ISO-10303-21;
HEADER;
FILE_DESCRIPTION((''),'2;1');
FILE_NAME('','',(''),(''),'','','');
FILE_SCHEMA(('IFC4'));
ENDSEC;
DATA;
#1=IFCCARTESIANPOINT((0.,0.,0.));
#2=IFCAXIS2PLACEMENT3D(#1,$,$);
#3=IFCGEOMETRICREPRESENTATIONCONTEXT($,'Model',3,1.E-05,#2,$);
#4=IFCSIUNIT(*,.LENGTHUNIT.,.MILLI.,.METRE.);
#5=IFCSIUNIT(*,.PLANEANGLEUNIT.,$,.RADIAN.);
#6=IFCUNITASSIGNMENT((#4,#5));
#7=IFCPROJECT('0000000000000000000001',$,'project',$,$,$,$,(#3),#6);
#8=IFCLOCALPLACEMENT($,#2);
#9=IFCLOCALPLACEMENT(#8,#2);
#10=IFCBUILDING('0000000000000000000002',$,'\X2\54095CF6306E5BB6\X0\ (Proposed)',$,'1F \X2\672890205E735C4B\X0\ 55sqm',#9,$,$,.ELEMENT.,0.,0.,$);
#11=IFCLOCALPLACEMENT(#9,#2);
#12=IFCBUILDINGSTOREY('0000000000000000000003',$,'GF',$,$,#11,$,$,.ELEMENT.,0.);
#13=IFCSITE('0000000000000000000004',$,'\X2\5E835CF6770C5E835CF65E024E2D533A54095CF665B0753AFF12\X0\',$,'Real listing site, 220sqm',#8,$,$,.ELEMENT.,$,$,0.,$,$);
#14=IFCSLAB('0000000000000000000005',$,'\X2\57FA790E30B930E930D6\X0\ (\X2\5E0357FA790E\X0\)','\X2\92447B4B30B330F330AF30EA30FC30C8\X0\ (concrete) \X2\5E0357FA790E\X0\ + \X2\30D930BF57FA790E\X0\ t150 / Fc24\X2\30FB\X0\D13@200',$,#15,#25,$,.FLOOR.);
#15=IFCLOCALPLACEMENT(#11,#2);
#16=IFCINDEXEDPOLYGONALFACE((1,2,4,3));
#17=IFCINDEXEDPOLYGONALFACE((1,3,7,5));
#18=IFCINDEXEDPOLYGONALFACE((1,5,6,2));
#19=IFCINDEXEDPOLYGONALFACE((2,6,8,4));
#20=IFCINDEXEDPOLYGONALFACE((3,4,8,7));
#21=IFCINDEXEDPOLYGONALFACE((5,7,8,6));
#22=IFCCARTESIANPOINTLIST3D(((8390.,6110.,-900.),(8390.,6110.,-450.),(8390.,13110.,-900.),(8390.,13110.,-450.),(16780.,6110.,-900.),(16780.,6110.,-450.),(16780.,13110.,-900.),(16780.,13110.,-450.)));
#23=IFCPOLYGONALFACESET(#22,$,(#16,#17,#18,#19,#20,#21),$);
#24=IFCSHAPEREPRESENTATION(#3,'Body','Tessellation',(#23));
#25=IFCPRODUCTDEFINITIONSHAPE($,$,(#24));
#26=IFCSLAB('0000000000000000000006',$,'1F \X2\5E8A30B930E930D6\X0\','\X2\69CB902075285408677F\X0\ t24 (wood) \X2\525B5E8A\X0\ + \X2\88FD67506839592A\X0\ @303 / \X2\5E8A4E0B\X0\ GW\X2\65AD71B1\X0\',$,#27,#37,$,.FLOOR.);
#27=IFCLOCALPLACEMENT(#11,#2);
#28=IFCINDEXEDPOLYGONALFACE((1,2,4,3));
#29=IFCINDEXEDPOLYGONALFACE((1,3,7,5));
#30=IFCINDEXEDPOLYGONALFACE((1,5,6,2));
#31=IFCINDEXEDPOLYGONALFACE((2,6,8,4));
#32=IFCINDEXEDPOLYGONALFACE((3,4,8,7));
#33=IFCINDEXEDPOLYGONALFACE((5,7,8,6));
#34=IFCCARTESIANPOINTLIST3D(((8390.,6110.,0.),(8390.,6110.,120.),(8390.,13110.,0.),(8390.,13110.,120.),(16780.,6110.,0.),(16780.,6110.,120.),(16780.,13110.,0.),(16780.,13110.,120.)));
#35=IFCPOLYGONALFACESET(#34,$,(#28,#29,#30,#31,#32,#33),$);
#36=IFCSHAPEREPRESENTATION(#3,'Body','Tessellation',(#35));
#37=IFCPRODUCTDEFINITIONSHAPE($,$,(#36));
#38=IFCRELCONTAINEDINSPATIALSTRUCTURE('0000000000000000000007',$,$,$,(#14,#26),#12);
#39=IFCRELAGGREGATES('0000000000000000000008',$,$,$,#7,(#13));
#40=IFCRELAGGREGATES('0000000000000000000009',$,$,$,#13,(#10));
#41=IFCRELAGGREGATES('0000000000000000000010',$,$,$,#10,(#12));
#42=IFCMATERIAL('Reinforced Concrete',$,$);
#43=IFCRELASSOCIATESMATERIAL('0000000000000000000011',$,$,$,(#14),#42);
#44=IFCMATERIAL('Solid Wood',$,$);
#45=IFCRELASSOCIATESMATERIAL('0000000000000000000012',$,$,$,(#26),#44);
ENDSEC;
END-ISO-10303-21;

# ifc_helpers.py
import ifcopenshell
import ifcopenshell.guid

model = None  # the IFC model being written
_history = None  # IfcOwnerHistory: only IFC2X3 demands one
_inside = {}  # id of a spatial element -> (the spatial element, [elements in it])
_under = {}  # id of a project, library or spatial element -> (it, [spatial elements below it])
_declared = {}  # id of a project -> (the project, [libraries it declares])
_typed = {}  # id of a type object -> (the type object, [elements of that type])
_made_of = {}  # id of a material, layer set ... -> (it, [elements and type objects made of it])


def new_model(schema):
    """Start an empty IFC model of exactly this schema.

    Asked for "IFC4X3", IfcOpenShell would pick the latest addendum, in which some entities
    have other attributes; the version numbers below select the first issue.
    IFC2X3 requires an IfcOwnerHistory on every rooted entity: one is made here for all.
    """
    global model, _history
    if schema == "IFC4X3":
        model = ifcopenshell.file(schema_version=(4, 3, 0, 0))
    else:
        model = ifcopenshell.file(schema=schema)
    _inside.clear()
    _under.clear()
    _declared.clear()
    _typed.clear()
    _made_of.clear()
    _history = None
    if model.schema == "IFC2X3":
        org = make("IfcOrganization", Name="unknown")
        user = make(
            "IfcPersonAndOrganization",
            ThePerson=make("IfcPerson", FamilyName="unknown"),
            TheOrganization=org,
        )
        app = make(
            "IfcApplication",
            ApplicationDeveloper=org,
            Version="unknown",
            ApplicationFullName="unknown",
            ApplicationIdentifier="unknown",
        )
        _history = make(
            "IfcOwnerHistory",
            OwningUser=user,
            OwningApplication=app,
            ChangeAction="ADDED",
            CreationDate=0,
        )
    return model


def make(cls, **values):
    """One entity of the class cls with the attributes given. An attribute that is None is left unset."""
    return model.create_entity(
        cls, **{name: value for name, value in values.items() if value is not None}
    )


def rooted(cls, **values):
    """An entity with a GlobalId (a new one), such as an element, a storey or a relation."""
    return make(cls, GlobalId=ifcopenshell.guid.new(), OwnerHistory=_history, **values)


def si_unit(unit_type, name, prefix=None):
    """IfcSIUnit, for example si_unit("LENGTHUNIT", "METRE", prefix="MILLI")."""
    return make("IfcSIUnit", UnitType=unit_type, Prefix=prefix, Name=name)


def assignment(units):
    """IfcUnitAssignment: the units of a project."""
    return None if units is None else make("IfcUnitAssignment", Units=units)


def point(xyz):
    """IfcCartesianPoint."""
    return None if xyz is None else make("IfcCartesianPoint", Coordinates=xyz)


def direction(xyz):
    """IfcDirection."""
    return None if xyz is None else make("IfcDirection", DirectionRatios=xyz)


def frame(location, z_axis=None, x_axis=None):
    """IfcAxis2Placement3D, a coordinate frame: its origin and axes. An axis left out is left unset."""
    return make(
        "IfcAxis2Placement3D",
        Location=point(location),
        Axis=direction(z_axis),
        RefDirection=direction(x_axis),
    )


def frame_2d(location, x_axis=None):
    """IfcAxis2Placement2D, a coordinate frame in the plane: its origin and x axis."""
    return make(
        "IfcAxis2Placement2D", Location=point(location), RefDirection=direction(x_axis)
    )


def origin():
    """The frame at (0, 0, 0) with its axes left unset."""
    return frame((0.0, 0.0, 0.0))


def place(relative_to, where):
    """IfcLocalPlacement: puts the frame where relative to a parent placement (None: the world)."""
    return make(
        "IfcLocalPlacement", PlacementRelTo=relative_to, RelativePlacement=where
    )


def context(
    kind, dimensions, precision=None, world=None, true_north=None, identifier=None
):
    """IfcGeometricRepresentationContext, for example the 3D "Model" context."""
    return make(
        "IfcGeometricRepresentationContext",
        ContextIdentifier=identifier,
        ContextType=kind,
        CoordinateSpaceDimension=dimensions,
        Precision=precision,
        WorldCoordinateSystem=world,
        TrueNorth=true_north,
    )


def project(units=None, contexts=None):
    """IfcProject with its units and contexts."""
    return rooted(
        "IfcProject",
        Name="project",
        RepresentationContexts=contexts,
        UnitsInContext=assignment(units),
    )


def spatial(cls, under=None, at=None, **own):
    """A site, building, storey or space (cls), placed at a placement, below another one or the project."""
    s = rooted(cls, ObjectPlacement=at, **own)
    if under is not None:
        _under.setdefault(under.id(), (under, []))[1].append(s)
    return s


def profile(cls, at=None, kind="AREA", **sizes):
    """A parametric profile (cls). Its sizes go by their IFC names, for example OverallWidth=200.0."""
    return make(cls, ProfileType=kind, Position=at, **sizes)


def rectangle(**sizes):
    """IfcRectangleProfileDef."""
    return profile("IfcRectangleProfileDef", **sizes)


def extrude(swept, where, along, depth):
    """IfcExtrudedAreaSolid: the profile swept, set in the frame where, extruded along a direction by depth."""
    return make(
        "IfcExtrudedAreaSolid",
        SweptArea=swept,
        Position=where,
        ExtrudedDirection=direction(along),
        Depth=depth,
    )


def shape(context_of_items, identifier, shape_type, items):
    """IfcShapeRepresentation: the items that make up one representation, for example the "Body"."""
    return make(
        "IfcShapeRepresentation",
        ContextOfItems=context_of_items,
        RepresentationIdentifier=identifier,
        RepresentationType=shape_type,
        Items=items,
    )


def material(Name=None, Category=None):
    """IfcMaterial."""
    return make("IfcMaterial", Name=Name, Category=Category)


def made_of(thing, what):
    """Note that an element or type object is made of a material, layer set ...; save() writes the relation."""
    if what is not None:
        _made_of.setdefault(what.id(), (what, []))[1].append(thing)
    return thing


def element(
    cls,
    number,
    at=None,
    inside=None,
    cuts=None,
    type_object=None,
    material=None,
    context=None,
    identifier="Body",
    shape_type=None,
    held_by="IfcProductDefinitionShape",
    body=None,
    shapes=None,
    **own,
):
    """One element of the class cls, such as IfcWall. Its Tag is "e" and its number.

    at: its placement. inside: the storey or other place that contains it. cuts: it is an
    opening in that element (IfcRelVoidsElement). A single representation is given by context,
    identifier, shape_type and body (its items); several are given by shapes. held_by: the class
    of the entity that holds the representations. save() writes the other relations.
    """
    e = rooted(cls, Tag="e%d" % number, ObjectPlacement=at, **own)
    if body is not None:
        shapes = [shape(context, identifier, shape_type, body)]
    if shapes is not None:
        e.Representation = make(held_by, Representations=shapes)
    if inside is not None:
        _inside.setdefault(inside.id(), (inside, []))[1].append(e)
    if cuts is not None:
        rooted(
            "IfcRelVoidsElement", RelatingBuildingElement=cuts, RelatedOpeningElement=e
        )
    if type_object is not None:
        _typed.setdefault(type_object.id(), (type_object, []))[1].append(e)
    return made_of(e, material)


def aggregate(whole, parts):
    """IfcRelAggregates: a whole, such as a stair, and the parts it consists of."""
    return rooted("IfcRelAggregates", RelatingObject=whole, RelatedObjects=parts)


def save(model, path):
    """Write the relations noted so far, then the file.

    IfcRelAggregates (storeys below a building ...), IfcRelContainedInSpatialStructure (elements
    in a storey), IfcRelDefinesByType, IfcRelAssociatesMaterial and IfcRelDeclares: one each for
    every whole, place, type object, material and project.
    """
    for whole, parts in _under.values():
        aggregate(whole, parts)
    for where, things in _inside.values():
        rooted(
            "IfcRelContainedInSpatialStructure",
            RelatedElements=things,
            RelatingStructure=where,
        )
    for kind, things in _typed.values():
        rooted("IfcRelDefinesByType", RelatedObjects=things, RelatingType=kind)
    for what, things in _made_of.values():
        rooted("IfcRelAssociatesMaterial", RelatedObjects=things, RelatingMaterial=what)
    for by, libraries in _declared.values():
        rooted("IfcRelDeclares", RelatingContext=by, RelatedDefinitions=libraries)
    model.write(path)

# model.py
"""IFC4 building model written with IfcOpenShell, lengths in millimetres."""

from ifc_helpers import new_model, si_unit, frame, frame_2d, origin, place, context, project, spatial, rectangle, extrude, material, element, save


model = new_model("IFC4")

# Units and contexts
model_context = context("Model", 3, precision=1e-05, world=origin())
ifc_project = project(units=[si_unit("LENGTHUNIT", "METRE", prefix="MILLI"), si_unit("PLANEANGLEUNIT", "RADIAN")], contexts=[model_context])

# Site, building, storey
site_placement = place(None, origin())
site = spatial("IfcSite", under=ifc_project, at=site_placement, Name="広島県広島市中区吉島新町２", ObjectType="Real listing site, 220sqm", CompositionType="ELEMENT", RefElevation=0.0)
building_placement = place(site_placement, origin())
building = spatial("IfcBuilding", under=site, at=building_placement, Name="吉島の家 (Proposed)", ObjectType="1F 木造平屋 55sqm", CompositionType="ELEMENT", ElevationOfRefHeight=0.0, ElevationOfTerrain=0.0)
storey_placement = place(building_placement, origin())
storey = spatial("IfcBuildingStorey", under=building, at=storey_placement, Name="GF", CompositionType="ELEMENT", Elevation=0.0)

# Slabs
ifc_material_1 = material(Name="Reinforced Concrete")
slab_1_placement = place(storey_placement, frame((4195.0, 3055.0, -450.0)))
element("IfcSlab", 1, at=slab_1_placement, inside=storey, material=ifc_material_1, Name="基礎スラブ (布基礎)", Description="鉄筋コンクリート (concrete) 布基礎 + ベタ基礎 t150 / Fc24・D13@200", PredefinedType="FLOOR", context=model_context, shape_type="SweptSolid", body=[
    extrude(rectangle(XDim=8390.0, YDim=7000.0, at=frame_2d((4195.0, 3500.0))), frame((4195.0, 3055.0, -450.0)), (0.0, 0.0, 1.0), 450.0),
])
ifc_material_2 = material(Name="Solid Wood")
slab_2_placement = place(storey_placement, frame((4195.0, 3055.0, 0.0)))
element("IfcSlab", 2, at=slab_2_placement, inside=storey, material=ifc_material_2, Name="1F 床スラブ", Description="構造用合板 t24 (wood) 剛床 + 製材根太 @303 / 床下 GW断熱", PredefinedType="FLOOR", context=model_context, shape_type="SweptSolid", body=[
    extrude(rectangle(XDim=8390.0, YDim=7000.0, at=frame_2d((4195.0, 3500.0))), frame((4195.0, 3055.0, 0.0)), (0.0, 0.0, 1.0), 120.0),
])

save(model, "model.ifc")
